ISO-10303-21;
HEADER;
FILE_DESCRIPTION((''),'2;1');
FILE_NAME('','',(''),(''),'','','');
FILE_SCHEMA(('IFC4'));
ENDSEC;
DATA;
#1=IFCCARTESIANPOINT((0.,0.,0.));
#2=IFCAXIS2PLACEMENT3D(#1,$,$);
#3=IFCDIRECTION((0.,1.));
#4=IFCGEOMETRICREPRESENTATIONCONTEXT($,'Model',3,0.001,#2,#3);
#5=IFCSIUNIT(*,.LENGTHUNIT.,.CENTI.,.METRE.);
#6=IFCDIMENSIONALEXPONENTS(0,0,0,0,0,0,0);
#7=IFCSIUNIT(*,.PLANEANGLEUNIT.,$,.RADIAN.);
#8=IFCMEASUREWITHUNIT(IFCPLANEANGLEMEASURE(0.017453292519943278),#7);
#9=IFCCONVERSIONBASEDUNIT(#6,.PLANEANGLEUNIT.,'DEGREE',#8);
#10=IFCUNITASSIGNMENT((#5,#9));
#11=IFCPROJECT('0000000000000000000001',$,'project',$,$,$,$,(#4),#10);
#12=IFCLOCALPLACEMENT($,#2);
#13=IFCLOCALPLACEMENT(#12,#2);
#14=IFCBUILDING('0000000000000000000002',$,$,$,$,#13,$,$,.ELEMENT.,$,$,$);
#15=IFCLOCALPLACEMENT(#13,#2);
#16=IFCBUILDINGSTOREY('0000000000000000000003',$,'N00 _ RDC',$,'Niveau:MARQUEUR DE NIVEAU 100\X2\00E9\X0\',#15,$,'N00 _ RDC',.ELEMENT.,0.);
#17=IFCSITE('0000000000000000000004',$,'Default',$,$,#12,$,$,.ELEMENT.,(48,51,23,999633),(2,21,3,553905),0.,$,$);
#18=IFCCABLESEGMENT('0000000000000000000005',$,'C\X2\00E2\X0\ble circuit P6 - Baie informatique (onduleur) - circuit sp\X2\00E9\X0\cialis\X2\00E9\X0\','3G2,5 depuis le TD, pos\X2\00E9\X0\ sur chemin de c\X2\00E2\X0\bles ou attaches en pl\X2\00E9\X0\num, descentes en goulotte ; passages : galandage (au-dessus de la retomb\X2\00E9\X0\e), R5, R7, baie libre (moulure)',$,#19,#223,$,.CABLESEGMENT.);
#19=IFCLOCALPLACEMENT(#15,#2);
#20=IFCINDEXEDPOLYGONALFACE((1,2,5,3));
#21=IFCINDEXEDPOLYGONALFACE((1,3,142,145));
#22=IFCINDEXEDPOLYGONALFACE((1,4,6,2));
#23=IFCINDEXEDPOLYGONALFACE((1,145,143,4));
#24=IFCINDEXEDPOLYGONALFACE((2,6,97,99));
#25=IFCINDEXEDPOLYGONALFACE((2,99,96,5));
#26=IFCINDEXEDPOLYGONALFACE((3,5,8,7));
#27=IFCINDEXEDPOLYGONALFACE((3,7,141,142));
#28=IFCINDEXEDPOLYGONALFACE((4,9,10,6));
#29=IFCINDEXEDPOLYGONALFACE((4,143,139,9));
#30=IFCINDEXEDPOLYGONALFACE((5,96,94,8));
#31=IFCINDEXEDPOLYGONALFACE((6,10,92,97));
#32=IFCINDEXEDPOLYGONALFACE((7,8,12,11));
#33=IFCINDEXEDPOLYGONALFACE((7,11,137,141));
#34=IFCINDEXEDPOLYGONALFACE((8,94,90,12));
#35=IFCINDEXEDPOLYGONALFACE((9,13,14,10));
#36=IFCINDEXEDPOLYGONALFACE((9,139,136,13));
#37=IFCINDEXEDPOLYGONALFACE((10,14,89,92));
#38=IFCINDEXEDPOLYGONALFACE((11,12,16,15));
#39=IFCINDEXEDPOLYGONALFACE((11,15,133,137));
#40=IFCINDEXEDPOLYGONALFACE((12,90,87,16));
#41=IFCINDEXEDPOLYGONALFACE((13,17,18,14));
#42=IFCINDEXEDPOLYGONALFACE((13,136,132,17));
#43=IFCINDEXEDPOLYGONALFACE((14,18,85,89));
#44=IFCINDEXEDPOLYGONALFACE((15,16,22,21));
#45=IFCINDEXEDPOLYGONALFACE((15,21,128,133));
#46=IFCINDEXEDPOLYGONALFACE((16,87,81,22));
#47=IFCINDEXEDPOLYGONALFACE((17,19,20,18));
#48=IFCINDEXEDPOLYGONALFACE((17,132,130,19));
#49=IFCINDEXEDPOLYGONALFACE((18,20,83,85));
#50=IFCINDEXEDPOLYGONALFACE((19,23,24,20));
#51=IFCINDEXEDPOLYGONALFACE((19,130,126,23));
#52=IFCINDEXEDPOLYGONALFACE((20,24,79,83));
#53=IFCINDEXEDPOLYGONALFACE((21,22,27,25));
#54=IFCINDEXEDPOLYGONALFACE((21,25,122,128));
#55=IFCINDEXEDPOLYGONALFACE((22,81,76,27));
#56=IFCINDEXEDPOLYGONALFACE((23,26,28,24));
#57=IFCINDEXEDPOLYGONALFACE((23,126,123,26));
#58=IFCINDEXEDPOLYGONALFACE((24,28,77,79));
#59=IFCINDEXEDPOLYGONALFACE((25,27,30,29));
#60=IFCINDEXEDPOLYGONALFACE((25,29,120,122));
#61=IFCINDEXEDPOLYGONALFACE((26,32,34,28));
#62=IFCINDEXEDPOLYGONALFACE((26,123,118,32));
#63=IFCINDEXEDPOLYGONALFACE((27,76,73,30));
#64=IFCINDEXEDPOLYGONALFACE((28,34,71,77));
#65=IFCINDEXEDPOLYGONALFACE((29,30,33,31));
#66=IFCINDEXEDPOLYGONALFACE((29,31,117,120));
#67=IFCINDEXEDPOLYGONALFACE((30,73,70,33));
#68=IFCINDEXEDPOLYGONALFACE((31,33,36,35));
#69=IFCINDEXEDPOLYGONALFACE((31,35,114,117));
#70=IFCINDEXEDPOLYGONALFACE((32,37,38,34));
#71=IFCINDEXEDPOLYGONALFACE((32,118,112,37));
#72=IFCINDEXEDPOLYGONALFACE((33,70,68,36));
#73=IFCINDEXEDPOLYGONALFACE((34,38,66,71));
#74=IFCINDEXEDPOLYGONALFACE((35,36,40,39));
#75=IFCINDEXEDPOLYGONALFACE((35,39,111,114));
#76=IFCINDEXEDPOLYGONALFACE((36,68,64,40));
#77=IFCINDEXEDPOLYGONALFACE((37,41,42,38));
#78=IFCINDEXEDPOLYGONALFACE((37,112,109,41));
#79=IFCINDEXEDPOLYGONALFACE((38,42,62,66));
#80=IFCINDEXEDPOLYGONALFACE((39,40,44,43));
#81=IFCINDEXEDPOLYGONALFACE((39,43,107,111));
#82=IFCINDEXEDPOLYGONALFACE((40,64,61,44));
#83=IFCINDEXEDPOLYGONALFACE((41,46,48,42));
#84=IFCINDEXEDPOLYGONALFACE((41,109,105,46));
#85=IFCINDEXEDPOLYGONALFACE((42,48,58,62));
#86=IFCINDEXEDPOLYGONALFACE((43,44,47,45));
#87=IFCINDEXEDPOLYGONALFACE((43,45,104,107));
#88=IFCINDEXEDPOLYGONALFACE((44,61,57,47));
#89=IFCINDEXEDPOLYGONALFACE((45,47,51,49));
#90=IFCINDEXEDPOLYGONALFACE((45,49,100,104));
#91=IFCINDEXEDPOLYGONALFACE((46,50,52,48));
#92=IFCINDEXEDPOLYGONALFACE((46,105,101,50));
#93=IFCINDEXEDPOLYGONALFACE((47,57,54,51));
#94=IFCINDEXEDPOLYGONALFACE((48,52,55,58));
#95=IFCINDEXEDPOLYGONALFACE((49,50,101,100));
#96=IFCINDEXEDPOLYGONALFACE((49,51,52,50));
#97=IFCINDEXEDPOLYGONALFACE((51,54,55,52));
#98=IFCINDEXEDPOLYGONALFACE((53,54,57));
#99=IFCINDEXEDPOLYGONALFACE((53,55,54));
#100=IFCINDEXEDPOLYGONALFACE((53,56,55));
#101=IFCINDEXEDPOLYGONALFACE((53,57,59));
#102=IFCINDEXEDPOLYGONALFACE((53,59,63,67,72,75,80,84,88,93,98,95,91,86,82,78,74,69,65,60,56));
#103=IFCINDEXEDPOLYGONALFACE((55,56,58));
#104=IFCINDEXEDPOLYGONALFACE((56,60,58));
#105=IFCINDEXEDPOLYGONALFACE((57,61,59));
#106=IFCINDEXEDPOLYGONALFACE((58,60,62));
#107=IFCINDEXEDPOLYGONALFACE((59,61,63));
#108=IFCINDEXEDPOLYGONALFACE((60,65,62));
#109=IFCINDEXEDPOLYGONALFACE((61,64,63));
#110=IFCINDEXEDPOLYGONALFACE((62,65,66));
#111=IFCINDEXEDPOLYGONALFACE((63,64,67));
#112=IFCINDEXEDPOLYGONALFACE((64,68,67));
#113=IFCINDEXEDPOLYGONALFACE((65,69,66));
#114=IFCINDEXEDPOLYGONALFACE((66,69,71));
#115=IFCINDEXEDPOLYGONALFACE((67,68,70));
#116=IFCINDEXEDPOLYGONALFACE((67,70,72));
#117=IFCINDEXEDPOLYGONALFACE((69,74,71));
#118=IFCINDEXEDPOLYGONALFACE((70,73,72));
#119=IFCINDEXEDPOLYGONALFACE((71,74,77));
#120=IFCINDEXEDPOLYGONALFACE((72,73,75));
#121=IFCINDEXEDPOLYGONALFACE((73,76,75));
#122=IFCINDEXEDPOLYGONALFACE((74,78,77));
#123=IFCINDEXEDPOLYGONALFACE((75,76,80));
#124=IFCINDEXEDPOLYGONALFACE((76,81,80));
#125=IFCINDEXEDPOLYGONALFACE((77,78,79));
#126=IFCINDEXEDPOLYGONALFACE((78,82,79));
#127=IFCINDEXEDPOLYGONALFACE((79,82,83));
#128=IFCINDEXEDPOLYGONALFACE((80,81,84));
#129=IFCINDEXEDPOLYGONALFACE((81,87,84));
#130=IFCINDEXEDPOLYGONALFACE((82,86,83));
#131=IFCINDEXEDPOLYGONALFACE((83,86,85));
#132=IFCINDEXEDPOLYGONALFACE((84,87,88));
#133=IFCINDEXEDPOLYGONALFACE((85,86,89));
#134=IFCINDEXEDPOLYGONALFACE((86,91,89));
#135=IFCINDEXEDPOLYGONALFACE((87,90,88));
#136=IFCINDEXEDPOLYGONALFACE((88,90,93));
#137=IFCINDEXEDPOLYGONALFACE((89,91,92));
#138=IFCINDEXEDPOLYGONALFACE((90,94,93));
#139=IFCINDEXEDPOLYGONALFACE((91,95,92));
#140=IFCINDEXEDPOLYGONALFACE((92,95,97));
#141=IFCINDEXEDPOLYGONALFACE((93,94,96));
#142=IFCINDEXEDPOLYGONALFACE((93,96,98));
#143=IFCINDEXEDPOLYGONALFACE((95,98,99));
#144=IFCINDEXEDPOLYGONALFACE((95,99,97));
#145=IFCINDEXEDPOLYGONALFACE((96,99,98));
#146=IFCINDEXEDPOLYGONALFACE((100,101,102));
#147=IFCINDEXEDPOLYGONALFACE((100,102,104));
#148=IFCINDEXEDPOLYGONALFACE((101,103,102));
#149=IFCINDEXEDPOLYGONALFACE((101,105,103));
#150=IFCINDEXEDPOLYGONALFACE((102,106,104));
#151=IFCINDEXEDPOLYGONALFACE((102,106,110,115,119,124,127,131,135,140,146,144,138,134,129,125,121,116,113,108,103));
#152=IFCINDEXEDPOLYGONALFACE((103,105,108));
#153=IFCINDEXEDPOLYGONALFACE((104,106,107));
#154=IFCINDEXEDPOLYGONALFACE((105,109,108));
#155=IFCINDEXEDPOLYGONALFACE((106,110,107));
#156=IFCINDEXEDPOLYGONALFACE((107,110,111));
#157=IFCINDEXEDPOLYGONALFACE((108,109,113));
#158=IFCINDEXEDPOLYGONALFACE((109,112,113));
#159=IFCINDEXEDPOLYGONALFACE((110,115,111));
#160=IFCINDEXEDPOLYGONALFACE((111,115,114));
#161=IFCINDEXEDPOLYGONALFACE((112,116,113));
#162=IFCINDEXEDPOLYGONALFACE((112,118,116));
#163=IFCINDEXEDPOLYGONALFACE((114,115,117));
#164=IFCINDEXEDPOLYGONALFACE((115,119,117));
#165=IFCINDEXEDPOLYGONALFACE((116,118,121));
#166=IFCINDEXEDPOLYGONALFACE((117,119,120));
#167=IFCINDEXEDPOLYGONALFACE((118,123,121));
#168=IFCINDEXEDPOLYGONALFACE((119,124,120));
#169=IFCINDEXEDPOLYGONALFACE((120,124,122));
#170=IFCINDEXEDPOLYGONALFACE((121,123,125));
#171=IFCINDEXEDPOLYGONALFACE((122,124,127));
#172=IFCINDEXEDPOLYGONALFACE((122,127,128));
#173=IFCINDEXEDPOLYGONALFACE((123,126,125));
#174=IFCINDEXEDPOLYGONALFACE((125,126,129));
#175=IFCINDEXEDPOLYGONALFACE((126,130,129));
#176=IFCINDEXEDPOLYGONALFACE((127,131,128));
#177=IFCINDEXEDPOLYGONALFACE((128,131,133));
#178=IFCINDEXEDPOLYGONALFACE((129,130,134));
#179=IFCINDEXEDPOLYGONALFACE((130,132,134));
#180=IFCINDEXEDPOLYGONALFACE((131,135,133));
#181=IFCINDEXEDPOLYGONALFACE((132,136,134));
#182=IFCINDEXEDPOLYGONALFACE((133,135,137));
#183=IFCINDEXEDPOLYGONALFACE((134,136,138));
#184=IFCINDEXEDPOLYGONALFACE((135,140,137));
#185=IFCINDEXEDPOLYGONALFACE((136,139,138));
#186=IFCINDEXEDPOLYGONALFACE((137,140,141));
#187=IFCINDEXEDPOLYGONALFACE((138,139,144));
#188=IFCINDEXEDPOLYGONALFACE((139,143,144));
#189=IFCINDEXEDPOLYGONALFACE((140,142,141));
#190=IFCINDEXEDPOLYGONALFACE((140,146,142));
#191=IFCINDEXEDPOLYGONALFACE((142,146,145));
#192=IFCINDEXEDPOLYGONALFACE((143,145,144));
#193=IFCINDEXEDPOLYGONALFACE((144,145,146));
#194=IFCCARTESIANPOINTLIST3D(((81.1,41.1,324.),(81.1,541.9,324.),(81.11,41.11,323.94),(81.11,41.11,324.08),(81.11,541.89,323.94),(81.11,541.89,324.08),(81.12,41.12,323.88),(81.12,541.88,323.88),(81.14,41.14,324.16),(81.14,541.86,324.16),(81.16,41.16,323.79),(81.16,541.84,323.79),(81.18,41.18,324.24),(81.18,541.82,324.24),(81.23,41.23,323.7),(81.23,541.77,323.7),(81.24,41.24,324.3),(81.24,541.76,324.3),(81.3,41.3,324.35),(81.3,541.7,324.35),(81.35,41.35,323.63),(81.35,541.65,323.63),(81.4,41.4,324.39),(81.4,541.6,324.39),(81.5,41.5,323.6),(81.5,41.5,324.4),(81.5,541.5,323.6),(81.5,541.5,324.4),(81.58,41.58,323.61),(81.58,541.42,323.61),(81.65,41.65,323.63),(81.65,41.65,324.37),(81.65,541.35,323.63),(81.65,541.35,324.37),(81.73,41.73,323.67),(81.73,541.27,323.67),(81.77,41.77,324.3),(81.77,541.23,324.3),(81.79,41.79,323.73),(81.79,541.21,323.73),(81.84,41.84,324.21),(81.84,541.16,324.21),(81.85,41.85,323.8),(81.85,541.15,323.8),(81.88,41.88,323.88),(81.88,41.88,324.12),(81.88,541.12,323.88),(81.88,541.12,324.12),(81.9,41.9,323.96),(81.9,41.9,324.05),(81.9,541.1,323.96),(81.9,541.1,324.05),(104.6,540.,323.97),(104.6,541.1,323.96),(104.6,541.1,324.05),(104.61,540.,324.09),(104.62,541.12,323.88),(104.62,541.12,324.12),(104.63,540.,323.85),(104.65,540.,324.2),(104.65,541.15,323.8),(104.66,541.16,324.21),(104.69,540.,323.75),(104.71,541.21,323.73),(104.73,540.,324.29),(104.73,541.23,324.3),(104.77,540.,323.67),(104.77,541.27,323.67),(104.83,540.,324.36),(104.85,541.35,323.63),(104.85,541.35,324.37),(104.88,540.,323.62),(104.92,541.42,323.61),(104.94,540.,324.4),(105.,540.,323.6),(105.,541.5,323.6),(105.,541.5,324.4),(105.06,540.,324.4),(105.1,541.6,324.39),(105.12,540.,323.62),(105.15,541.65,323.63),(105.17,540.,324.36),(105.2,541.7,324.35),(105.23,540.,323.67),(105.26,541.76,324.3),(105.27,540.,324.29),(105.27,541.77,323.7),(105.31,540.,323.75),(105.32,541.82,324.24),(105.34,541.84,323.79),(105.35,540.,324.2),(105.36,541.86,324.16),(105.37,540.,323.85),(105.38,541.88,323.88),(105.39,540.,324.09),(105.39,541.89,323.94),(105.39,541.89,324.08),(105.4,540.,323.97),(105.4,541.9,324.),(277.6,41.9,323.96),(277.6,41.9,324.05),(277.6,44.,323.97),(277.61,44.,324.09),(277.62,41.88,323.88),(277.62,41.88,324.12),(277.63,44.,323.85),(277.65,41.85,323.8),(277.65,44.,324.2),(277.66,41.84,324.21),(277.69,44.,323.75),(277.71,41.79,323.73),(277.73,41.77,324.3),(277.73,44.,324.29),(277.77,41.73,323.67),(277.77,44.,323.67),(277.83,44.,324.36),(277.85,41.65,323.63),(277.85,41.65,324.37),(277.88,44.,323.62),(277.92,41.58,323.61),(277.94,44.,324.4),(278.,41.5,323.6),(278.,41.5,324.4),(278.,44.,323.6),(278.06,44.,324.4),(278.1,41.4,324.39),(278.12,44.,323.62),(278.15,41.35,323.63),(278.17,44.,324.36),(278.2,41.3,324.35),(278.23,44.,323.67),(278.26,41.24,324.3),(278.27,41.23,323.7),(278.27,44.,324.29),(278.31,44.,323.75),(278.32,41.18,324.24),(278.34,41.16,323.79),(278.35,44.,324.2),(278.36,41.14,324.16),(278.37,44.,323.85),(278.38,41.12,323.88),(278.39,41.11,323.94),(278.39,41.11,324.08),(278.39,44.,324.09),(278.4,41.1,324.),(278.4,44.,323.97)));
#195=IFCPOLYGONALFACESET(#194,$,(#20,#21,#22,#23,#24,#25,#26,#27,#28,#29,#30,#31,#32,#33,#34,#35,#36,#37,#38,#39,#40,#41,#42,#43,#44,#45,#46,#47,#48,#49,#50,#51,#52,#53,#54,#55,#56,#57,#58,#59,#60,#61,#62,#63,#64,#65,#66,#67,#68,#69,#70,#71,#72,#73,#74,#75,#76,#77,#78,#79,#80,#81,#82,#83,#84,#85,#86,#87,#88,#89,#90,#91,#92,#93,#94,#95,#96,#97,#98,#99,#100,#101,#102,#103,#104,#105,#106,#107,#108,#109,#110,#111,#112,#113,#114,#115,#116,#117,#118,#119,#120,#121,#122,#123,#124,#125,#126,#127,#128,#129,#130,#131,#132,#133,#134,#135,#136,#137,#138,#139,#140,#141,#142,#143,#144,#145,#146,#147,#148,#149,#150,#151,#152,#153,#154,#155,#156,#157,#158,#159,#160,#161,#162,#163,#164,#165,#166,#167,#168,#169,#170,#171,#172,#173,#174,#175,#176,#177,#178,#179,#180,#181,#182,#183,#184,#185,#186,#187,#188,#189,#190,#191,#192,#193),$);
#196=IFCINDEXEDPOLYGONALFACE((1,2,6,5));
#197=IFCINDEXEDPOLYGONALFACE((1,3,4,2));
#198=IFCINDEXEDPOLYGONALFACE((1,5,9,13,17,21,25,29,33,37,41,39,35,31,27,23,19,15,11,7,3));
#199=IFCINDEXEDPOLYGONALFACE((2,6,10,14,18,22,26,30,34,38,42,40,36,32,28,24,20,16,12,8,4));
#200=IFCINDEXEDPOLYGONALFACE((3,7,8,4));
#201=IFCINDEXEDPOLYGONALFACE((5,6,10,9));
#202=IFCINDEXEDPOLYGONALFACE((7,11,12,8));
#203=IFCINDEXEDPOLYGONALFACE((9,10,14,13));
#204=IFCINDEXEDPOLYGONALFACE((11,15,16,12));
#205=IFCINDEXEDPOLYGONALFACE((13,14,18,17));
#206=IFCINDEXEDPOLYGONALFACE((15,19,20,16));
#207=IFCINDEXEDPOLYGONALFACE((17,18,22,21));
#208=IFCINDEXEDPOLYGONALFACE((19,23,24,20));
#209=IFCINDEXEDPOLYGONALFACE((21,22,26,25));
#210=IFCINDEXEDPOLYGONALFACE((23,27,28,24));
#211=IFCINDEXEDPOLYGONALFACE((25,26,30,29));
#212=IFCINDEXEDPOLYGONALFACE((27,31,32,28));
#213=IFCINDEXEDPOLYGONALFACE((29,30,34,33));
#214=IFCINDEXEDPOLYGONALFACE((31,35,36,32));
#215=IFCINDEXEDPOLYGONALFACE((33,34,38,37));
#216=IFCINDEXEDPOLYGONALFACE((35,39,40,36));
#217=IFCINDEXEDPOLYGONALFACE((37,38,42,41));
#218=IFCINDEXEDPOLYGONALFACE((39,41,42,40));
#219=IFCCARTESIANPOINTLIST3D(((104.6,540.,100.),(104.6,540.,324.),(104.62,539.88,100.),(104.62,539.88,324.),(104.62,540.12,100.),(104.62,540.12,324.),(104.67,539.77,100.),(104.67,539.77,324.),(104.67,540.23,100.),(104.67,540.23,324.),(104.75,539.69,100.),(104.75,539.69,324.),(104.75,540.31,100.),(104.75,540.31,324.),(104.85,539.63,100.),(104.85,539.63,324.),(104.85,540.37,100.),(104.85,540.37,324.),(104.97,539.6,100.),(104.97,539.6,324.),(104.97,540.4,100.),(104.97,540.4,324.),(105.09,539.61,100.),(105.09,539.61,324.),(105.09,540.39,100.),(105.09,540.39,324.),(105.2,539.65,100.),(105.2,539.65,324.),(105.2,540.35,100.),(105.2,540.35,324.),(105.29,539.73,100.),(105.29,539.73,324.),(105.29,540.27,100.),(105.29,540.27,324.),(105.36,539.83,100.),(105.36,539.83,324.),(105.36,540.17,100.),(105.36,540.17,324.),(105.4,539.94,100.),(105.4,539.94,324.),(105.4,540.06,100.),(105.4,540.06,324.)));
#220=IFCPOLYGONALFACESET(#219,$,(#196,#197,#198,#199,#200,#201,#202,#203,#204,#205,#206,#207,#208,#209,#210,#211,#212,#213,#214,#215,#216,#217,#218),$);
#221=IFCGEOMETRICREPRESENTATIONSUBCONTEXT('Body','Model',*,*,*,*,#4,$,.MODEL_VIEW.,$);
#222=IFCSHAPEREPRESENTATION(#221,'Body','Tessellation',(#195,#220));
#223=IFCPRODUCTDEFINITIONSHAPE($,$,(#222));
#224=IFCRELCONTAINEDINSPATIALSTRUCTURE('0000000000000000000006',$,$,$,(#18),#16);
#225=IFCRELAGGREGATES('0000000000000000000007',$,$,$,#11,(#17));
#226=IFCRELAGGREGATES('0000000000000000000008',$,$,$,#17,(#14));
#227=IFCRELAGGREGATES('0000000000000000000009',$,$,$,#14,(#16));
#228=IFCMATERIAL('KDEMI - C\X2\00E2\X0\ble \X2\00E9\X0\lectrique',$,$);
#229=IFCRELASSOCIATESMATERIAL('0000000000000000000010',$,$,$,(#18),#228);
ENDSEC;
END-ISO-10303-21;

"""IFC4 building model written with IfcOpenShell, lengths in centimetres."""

from ifc_helpers import new_model, entity, si_unit, converted_unit, direction, origin, origin_with_axes, place, context, subcontext, project, spatial, material, element, save


model = new_model("IFC4")

# Units and contexts
model_context = context("Model", 3, precision=0.001, world=origin(), true_north=direction((0.0, 1.0)))
body_context = subcontext(model_context, "Body", "Model", "MODEL_VIEW")
ifc_project = project(units=[si_unit("LENGTHUNIT", "METRE", prefix="CENTI"), converted_unit("PLANEANGLEUNIT", "DEGREE", entity("IfcPlaneAngleMeasure", 0.017453292519943278), si_unit("PLANEANGLEUNIT", "RADIAN"), dimensions=[0, 0, 0, 0, 0, 0, 0])], contexts=[model_context])

# Site, building, storey
site_placement = place(None, origin())
site = spatial("IfcSite", under=ifc_project, at=site_placement, Name="Default", CompositionType="ELEMENT", RefLatitude=(48, 51, 23, 999633), RefLongitude=(2, 21, 3, 553905), RefElevation=0.0)
building_placement = place(site_placement, origin())
building = spatial("IfcBuilding", under=site, at=building_placement, CompositionType="ELEMENT")
storey_placement = place(building_placement, origin())
storey = spatial("IfcBuildingStorey", under=building, at=storey_placement, Name="N00 _ RDC", ObjectType="Niveau:MARQUEUR DE NIVEAU 100é", LongName="N00 _ RDC", CompositionType="ELEMENT", Elevation=0.0)

# Cable segment
ifc_material_1 = material(Name="KDEMI - Câble électrique")
cable_segment_1_placement = place(storey_placement, origin_with_axes())
element("IfcCableSegment", 1, at=cable_segment_1_placement, inside=storey, material=ifc_material_1, Name="Câble circuit P6 - Baie informatique (onduleur) - circuit spécialisé", Description="3G2,5 depuis le TD, posé sur chemin de câbles ou attaches en plénum, descentes en goulotte ; passages : galandage (au-dessus de la retombée), R5, R7, baie libre (moulure)", PredefinedType="CABLESEGMENT", context=body_context, shape_type="AdvancedSweptSolid", body=[
    entity("IfcSweptDiskSolid", entity("IfcPolyline", [entity("IfcCartesianPoint", [278.0, 44.0, 324.0]), entity("IfcCartesianPoint", [278.0, 41.5, 324.0]), entity("IfcCartesianPoint", [81.5, 41.5, 324.0]), entity("IfcCartesianPoint", [81.5, 541.5, 324.0]), entity("IfcCartesianPoint", [105.0, 541.5, 324.0]), entity("IfcCartesianPoint", [105.0, 540.0, 324.0])]), 0.4),
    entity("IfcSweptDiskSolid", entity("IfcPolyline", [entity("IfcCartesianPoint", [105.0, 540.0, 324.0]), entity("IfcCartesianPoint", [105.0, 540.0, 100.0])]), 0.4),
])

save(model, "model.ifc")
